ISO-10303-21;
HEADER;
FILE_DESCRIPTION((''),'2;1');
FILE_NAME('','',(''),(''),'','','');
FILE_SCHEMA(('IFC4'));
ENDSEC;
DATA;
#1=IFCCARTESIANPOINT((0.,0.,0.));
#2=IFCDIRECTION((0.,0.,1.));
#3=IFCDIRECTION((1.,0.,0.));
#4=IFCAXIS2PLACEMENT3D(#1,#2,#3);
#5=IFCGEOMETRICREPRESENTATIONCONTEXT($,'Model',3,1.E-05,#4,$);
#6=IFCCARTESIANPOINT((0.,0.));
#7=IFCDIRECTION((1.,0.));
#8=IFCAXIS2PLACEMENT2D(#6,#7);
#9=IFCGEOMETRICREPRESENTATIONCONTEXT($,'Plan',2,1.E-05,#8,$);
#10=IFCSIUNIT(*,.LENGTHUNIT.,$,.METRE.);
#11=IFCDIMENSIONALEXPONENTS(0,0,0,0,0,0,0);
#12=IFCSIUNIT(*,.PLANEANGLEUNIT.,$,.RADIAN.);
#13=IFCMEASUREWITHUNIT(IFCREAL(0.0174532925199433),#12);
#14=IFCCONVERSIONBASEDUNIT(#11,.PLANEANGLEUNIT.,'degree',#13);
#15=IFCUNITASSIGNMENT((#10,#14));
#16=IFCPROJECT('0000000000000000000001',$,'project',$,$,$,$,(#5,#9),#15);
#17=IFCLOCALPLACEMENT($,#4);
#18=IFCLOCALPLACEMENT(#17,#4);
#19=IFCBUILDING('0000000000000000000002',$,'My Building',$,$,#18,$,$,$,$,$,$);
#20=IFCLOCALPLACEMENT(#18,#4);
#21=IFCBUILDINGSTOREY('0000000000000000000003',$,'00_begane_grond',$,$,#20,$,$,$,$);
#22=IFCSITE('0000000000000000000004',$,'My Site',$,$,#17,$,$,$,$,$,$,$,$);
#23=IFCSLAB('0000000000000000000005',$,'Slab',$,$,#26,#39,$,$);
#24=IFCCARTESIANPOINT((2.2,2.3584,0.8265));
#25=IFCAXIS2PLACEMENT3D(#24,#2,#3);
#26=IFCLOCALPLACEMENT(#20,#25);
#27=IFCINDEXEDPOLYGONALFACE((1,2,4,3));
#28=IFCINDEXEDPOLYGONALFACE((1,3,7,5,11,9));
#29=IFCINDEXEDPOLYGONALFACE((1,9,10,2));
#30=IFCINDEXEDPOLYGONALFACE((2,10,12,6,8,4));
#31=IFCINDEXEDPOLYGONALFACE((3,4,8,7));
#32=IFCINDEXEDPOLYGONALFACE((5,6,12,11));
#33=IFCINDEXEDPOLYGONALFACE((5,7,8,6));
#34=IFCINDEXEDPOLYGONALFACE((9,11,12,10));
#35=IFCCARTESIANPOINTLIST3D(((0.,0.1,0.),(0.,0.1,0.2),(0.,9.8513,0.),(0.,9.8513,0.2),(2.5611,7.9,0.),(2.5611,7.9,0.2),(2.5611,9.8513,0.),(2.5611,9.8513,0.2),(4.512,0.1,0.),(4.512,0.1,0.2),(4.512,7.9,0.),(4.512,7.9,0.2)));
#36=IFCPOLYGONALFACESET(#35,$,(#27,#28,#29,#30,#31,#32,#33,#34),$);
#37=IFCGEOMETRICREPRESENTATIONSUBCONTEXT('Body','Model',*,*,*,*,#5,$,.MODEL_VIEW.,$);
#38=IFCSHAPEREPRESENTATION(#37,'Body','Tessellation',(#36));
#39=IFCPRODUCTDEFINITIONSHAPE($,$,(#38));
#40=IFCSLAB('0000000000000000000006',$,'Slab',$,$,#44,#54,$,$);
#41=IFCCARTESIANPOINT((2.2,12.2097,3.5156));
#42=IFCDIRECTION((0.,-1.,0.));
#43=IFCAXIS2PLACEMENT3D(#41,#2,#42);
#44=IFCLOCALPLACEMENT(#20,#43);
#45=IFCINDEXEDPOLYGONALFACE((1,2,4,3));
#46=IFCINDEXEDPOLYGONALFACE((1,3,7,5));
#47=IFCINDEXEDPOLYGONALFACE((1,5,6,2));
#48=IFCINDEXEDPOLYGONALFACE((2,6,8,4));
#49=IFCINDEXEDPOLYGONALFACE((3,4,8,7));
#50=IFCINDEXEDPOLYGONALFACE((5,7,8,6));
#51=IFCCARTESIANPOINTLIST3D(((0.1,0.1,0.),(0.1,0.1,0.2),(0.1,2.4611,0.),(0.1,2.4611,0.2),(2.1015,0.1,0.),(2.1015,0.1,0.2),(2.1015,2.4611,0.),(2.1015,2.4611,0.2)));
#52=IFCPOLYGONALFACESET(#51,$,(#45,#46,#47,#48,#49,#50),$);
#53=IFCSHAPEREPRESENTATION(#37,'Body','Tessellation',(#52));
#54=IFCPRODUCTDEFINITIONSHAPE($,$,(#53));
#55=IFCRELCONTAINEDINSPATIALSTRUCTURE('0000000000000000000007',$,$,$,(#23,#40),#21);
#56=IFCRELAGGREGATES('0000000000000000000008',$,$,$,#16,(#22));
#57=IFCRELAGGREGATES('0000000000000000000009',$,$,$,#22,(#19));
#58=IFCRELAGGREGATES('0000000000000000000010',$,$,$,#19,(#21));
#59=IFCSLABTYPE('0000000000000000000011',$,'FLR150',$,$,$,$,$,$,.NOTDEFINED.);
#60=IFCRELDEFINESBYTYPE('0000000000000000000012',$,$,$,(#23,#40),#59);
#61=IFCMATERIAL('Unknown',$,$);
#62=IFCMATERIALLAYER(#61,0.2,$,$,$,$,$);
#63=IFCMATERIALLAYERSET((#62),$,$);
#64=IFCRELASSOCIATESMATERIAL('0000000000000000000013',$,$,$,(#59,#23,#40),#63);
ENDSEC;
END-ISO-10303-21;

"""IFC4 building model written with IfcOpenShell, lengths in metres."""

from ifc_helpers import new_model, entity, si_unit, converted_unit, frame, origin_with_axes, origin_2d_with_axis, place, context, subcontext, project, spatial, line, indexed_curve, outline, extrude, material, layer, layer_set, layer_usage, type_object, element, save


model = new_model("IFC4")

# Units and contexts
model_context = context("Model", 3, precision=1e-05, world=origin_with_axes())
plan_context = context("Plan", 2, precision=1e-05, world=origin_2d_with_axis())
body_context_1 = subcontext(model_context, "Body", "Model", "MODEL_VIEW")
ifc_project = project(units=[si_unit("LENGTHUNIT", "METRE"), converted_unit("PLANEANGLEUNIT", "degree", entity("IfcReal", 0.0174532925199433), si_unit("PLANEANGLEUNIT", "RADIAN"), dimensions=[0, 0, 0, 0, 0, 0, 0])], contexts=[model_context, plan_context])

# Site, building, storey
site_placement = place(None, origin_with_axes())
site = spatial("IfcSite", under=ifc_project, at=site_placement, Name="My Site")
building_placement = place(site_placement, origin_with_axes())
building = spatial("IfcBuilding", under=site, at=building_placement, Name="My Building")
storey_placement = place(building_placement, origin_with_axes())
storey = spatial("IfcBuildingStorey", under=building, at=storey_placement, Name="00_begane_grond")

# Slabs
ifc_material = material(Name="Unknown")
ifc_layer_1 = layer(ifc_material, 0.2)
ifc_layer_set_1 = layer_set([ifc_layer_1])
ifc_layer_usage_1 = layer_usage(ifc_layer_set_1, "AXIS3", "POSITIVE", 0.0)
slab_type = type_object("IfcSlabType", Name="FLR150", PredefinedType="NOTDEFINED", material=ifc_layer_set_1)
slab_1_placement = place(storey_placement, frame((2.2, 2.3584, 0.8265), z_axis=(0.0, 0.0, 1.0), x_axis=(1.0, 0.0, 0.0)))
element("IfcSlab", 1, at=slab_1_placement, inside=storey, type_object=slab_type, material=ifc_layer_usage_1, Name="Slab", context=body_context_1, shape_type="SweptSolid", body=[
    extrude(outline(indexed_curve([(0.0, 9.8513), (0.0, 0.1), (4.512, 0.1), (4.512, 7.9), (2.5611, 7.9), (2.5611, 9.8513)], segments=[line(6, 5), line(5, 4), line(4, 3), line(3, 2), line(2, 1), line(1, 6)], self_intersect=False)), None, (0.0, 0.0, 1.0), 0.2),
])
ifc_layer_usage_2 = layer_usage(ifc_layer_set_1, "AXIS3", "POSITIVE", 0.0)
slab_2_placement = place(storey_placement, frame((2.2, 12.2097, 3.5156), z_axis=(0.0, 0.0, 1.0), x_axis=(0.0, -1.0, 0.0)))
element("IfcSlab", 2, at=slab_2_placement, inside=storey, type_object=slab_type, material=ifc_layer_usage_2, Name="Slab", context=body_context_1, shape_type="SweptSolid", body=[
    extrude(outline(indexed_curve([(2.1015, 0.1), (0.1, 0.1), (0.1, 2.4611), (2.1015, 2.4611)], segments=[line(3, 2), line(2, 1), line(1, 4), line(4, 3)], self_intersect=False)), None, (0.0, 0.0, 1.0), 0.2),
])

save(model, "model.ifc")
